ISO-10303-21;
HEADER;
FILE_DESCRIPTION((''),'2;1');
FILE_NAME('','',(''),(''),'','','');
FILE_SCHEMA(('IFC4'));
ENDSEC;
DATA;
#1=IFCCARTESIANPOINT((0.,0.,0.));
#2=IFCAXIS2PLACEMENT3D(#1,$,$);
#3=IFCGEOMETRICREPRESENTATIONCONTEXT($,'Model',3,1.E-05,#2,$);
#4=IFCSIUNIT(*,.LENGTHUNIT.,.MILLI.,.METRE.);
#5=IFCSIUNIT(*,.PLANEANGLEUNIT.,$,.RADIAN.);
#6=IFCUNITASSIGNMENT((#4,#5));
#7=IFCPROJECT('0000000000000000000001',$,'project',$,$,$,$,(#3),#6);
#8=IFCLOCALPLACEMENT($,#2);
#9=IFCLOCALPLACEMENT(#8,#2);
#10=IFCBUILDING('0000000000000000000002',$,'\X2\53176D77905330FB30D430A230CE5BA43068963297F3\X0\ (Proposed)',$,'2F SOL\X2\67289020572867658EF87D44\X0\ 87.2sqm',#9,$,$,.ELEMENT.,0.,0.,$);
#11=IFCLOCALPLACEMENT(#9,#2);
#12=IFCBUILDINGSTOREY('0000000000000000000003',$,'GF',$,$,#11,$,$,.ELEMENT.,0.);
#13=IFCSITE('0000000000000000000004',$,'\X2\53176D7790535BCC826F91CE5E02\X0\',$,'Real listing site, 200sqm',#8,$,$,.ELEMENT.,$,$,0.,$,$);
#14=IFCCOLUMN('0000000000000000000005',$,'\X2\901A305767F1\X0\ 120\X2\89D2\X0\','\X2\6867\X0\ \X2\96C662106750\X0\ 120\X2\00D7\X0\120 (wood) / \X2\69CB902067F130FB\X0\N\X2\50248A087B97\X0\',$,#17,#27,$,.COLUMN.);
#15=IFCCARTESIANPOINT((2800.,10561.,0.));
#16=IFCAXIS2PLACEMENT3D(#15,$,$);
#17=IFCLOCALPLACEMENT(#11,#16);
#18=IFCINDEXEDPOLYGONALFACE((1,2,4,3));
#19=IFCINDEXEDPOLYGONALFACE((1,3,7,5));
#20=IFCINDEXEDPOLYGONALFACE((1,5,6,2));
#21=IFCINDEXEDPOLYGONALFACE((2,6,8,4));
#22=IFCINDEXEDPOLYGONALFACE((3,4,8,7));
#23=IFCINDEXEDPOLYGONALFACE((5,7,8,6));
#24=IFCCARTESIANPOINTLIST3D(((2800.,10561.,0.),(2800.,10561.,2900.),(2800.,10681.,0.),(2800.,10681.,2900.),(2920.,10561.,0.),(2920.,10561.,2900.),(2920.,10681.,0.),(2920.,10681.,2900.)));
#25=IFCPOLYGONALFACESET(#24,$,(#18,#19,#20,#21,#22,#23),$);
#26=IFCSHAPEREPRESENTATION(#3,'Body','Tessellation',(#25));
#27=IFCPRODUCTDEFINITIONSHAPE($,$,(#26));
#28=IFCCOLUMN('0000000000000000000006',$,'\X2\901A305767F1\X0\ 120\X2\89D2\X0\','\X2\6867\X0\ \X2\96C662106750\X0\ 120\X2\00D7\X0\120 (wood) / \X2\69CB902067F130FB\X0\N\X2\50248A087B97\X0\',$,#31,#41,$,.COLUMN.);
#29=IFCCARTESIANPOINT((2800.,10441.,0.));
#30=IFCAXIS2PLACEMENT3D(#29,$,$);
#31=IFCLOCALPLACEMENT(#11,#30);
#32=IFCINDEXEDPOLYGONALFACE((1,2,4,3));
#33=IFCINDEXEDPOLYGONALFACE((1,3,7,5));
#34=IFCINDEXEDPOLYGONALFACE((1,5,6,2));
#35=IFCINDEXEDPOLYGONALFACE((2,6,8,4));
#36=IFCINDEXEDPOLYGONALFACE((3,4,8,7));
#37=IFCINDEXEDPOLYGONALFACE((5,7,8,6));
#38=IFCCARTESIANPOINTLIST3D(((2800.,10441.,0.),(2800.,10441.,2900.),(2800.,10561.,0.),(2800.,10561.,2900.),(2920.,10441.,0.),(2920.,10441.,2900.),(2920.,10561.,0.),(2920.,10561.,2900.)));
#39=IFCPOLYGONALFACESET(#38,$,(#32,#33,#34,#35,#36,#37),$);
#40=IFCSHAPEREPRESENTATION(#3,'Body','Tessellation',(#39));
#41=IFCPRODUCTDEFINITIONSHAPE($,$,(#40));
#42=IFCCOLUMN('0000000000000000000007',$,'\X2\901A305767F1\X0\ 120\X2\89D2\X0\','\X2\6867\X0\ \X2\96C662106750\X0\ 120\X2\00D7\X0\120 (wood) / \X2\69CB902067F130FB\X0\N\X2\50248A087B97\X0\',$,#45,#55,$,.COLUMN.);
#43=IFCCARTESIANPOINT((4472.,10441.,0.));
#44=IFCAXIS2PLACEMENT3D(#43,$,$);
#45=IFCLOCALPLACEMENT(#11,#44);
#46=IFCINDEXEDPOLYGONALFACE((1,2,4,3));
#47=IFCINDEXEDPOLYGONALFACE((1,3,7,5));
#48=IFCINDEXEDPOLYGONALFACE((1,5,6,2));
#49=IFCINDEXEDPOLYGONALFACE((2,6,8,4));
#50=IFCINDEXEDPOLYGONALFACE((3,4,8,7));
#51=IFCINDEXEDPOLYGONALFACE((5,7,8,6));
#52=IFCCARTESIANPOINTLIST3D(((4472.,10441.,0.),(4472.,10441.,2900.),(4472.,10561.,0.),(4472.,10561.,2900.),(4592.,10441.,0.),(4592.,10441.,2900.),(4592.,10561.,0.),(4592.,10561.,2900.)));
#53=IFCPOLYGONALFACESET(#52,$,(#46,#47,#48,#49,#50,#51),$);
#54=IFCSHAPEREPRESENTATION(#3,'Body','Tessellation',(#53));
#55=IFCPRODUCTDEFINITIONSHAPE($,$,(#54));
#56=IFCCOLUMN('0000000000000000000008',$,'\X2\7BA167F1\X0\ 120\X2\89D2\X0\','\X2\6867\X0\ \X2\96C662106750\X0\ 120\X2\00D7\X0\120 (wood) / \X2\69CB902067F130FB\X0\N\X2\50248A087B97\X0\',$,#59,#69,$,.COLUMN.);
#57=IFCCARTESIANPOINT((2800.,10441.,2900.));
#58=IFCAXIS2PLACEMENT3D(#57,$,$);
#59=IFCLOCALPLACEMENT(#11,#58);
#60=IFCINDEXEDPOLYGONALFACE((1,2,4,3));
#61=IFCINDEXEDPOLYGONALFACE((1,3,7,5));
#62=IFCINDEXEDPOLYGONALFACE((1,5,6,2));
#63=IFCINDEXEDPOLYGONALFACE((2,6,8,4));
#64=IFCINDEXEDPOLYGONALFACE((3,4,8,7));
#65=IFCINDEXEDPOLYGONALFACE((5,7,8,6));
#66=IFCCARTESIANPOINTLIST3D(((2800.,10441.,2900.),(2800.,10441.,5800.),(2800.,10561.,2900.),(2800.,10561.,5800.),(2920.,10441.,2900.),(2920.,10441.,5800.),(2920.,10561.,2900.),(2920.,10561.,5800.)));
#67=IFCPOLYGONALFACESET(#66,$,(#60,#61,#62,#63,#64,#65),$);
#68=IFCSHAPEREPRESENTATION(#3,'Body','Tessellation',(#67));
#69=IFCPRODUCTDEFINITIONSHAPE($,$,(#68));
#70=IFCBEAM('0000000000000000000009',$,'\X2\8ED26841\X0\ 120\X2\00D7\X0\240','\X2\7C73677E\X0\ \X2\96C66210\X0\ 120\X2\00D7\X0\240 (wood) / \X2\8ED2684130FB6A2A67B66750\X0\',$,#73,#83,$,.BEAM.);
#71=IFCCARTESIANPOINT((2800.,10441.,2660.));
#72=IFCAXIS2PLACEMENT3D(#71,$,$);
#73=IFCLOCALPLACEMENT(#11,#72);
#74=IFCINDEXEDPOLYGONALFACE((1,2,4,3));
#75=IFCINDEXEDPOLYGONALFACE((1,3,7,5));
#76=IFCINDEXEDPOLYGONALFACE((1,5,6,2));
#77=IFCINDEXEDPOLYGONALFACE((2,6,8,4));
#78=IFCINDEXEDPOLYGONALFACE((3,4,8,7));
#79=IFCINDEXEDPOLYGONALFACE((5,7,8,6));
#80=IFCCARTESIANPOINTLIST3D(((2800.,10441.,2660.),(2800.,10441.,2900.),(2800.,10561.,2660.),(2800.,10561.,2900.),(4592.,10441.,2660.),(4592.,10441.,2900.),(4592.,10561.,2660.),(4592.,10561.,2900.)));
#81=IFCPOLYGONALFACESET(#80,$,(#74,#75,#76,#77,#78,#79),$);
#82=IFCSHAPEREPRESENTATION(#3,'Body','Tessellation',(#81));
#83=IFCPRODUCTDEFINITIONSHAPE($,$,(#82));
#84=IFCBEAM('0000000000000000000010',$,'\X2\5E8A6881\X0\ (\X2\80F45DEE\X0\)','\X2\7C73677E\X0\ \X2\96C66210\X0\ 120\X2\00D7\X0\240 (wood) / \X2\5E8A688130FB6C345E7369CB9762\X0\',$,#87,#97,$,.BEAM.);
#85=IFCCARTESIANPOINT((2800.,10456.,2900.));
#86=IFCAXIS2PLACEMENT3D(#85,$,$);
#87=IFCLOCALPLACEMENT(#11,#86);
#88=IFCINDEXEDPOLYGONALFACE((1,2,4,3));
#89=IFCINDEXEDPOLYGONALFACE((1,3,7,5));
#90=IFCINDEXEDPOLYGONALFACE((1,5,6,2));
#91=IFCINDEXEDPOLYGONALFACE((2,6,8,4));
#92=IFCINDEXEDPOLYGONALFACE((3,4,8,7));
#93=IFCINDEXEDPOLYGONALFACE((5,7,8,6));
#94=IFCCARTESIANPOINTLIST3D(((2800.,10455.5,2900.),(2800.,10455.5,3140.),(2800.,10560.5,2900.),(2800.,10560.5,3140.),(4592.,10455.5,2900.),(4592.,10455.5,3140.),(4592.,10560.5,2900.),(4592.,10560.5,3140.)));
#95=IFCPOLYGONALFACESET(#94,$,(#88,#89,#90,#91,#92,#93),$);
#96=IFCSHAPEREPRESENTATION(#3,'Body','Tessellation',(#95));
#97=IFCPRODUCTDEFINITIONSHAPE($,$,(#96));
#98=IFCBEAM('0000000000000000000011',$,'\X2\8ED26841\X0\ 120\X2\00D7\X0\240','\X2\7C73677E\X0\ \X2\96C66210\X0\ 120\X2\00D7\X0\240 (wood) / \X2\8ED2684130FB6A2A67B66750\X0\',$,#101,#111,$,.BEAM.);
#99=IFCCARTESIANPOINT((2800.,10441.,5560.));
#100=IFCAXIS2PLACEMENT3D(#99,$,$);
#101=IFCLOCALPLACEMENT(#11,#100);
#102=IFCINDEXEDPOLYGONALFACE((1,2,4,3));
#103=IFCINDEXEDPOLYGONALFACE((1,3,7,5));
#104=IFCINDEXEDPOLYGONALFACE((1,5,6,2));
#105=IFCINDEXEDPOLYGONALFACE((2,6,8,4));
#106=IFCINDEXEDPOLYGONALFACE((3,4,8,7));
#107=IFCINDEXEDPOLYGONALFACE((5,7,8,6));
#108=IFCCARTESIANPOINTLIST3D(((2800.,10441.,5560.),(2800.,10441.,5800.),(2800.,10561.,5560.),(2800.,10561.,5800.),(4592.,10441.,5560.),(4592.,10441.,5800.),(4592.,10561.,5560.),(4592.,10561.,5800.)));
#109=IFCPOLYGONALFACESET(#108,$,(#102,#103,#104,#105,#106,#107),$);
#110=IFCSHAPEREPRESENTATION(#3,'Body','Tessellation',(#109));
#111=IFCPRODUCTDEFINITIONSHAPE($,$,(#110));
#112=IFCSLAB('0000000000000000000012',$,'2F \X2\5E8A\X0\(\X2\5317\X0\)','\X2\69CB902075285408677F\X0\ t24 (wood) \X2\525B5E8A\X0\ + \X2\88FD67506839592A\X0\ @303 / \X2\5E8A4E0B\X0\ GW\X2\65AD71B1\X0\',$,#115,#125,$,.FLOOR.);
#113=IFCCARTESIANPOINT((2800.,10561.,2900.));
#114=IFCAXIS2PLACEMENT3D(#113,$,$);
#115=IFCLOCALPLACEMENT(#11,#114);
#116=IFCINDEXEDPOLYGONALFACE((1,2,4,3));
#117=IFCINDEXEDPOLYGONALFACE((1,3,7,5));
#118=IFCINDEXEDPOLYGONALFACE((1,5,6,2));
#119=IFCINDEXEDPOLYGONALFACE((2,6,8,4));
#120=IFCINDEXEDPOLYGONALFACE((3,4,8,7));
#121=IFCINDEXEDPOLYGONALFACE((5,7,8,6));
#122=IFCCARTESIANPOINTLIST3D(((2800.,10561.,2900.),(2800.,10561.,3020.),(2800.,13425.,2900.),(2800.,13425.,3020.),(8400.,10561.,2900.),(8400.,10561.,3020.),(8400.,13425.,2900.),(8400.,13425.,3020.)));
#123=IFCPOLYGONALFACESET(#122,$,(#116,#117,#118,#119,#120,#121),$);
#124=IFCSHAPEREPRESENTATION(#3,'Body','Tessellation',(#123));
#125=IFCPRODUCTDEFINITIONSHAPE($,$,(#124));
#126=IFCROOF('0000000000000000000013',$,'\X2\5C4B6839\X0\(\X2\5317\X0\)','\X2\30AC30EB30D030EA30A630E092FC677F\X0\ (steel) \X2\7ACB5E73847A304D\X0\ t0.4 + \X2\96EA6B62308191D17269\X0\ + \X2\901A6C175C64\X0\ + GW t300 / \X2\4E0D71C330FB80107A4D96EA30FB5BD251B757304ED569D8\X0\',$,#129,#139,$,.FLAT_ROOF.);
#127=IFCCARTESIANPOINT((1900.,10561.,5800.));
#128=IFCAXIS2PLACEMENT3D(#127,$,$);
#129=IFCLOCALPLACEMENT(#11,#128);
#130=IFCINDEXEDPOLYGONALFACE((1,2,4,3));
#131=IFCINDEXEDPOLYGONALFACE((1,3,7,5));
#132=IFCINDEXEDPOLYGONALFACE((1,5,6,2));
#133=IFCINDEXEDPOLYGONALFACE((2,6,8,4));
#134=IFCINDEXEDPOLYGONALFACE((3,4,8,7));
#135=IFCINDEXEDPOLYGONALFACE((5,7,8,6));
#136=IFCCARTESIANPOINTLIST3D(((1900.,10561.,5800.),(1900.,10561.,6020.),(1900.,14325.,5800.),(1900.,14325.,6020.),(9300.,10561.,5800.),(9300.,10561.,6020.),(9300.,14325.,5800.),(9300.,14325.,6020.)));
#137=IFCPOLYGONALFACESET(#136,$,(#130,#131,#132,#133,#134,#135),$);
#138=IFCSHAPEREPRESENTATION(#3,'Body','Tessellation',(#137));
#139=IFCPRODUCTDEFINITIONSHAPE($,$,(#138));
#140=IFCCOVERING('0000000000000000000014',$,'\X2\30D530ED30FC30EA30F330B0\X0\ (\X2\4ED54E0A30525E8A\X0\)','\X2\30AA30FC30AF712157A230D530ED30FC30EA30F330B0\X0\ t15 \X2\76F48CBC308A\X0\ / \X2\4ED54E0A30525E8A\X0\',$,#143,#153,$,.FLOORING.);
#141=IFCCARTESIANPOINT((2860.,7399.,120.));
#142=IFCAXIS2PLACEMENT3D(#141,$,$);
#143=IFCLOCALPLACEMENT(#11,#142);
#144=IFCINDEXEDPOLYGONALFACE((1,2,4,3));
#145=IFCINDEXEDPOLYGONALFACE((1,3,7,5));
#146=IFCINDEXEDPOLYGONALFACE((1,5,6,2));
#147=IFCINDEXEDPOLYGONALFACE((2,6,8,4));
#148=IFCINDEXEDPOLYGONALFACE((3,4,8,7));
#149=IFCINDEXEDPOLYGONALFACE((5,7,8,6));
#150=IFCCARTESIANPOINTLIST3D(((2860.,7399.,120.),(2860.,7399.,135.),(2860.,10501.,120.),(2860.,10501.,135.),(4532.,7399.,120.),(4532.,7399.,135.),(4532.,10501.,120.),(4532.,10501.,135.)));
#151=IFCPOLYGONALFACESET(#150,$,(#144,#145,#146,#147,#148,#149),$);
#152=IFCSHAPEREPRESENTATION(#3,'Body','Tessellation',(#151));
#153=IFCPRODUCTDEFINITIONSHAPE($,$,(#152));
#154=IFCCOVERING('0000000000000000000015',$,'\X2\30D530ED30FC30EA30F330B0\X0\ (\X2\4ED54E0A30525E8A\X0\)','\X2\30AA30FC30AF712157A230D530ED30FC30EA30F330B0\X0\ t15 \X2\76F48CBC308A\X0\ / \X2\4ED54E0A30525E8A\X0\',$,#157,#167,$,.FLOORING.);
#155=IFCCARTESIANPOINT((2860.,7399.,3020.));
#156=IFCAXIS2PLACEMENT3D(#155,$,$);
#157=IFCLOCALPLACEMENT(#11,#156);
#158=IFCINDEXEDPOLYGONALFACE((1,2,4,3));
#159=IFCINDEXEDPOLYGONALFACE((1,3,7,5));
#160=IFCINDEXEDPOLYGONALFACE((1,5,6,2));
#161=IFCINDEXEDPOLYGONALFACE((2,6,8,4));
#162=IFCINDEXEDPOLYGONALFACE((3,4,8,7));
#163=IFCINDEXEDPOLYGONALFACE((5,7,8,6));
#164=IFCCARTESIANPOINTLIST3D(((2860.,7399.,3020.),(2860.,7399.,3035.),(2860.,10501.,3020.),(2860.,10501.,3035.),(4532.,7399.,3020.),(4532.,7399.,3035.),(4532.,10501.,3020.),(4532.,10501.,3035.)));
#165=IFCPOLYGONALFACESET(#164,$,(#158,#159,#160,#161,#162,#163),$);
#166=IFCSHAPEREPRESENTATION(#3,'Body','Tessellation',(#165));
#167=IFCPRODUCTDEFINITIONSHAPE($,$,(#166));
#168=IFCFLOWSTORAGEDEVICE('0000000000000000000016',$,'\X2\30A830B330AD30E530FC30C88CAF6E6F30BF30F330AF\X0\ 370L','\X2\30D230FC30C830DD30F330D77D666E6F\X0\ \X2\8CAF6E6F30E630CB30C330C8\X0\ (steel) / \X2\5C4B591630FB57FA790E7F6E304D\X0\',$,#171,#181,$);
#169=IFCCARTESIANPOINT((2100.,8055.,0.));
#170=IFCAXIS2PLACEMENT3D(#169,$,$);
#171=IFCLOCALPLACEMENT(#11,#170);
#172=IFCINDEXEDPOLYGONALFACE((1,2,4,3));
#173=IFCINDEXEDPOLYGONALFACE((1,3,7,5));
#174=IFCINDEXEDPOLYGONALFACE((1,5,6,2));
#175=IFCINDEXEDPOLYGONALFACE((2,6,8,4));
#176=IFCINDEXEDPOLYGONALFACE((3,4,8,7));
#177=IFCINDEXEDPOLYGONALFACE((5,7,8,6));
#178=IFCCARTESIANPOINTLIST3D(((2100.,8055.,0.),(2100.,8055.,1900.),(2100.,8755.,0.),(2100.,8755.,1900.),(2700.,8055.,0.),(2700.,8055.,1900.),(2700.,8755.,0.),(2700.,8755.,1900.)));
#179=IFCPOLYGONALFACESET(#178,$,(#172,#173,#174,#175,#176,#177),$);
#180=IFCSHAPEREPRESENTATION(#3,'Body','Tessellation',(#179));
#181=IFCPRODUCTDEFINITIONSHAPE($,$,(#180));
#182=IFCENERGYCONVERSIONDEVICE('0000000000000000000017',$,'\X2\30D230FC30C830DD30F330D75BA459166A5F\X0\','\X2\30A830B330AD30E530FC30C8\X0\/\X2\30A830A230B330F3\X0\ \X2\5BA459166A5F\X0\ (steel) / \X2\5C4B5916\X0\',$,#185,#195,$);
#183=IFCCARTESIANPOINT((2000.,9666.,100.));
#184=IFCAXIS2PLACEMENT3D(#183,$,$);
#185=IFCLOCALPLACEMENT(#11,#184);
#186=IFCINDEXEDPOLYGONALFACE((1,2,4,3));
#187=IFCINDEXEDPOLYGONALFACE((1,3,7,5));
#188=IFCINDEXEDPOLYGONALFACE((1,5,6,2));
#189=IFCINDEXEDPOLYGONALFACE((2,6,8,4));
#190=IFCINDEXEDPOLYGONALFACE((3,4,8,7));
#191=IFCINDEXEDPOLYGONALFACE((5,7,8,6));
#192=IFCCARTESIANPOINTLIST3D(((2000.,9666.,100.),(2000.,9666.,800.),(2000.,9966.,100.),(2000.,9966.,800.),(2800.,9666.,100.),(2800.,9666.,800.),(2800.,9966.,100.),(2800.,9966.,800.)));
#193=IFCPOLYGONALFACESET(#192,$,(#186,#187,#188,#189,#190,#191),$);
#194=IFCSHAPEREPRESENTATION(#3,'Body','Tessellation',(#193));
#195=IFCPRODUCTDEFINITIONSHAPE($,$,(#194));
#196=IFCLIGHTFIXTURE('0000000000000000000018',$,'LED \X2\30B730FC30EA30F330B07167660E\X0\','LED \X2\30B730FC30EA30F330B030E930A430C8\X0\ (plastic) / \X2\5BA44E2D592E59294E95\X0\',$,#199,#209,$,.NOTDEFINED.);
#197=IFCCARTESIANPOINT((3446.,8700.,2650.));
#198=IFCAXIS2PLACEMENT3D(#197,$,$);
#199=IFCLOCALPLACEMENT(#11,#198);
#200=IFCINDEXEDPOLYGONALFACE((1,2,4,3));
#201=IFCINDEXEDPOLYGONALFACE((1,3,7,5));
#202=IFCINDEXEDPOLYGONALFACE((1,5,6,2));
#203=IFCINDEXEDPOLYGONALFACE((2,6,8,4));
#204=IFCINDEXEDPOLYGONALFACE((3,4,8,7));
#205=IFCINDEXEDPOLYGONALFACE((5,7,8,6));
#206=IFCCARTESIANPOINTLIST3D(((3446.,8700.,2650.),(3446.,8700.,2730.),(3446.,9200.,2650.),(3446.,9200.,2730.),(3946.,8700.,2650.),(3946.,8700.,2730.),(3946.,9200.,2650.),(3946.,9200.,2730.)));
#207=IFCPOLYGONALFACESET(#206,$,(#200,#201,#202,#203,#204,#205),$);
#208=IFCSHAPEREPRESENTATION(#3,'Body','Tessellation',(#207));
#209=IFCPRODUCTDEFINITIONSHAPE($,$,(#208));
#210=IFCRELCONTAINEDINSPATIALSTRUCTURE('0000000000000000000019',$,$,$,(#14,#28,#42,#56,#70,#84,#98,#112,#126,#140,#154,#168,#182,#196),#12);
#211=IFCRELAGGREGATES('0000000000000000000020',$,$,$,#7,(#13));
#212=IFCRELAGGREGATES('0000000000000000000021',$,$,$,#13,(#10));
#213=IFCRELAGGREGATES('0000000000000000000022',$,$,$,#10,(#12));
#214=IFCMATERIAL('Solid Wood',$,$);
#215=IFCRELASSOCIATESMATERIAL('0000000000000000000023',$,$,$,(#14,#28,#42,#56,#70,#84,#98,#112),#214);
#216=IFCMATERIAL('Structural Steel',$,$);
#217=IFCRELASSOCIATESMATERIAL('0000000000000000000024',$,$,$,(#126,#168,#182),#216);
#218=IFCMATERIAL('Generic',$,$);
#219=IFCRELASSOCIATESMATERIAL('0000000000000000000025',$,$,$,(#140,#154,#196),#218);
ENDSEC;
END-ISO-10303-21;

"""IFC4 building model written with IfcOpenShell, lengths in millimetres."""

from ifc_helpers import new_model, si_unit, frame, frame_2d, origin, place, context, project, spatial, rectangle, extrude, material, element, save


model = new_model("IFC4")

# Units and contexts
model_context = context("Model", 3, precision=1e-05, world=origin())
ifc_project = project(units=[si_unit("LENGTHUNIT", "METRE", prefix="MILLI"), si_unit("PLANEANGLEUNIT", "RADIAN")], contexts=[model_context])

# Site, building, storey
site_placement = place(None, origin())
site = spatial("IfcSite", under=ifc_project, at=site_placement, Name="北海道富良野市", ObjectType="Real listing site, 200sqm", CompositionType="ELEMENT", RefElevation=0.0)
building_placement = place(site_placement, origin())
building = spatial("IfcBuilding", under=site, at=building_placement, Name="北海道・ピアノ室と防音 (Proposed)", ObjectType="2F SOL木造在来軸組 87.2sqm", CompositionType="ELEMENT", ElevationOfRefHeight=0.0, ElevationOfTerrain=0.0)
storey_placement = place(building_placement, origin())
storey = spatial("IfcBuildingStorey", under=building, at=storey_placement, Name="GF", CompositionType="ELEMENT", Elevation=0.0)

# Columns
ifc_material_1 = material(Name="Solid Wood")
column_1_placement = place(storey_placement, frame((2800.0, 10561.0, 0.0)))
element("IfcColumn", 1, at=column_1_placement, inside=storey, material=ifc_material_1, Name="通し柱 120角", Description="桧 集成材 120×120 (wood) / 構造柱・N値計算", PredefinedType="COLUMN", context=model_context, shape_type="SweptSolid", body=[
    extrude(rectangle(XDim=120.0, YDim=120.0, at=frame_2d((60.0, 60.0))), frame((2800.0, 10561.0, 0.0)), (0.0, 0.0, 1.0), 2900.0),
])
column_2_placement = place(storey_placement, frame((2800.0, 10441.0, 0.0)))
element("IfcColumn", 2, at=column_2_placement, inside=storey, material=ifc_material_1, Name="通し柱 120角", Description="桧 集成材 120×120 (wood) / 構造柱・N値計算", PredefinedType="COLUMN", context=model_context, shape_type="SweptSolid", body=[
    extrude(rectangle(XDim=120.0, YDim=120.0, at=frame_2d((60.0, 60.0))), frame((2800.0, 10441.0, 0.0)), (0.0, 0.0, 1.0), 2900.0),
])
column_3_placement = place(storey_placement, frame((4472.0, 10441.0, 0.0)))
element("IfcColumn", 3, at=column_3_placement, inside=storey, material=ifc_material_1, Name="通し柱 120角", Description="桧 集成材 120×120 (wood) / 構造柱・N値計算", PredefinedType="COLUMN", context=model_context, shape_type="SweptSolid", body=[
    extrude(rectangle(XDim=120.0, YDim=120.0, at=frame_2d((60.0, 60.0))), frame((4472.0, 10441.0, 0.0)), (0.0, 0.0, 1.0), 2900.0),
])
column_4_placement = place(storey_placement, frame((2800.0, 10441.0, 2900.0)))
element("IfcColumn", 4, at=column_4_placement, inside=storey, material=ifc_material_1, Name="管柱 120角", Description="桧 集成材 120×120 (wood) / 構造柱・N値計算", PredefinedType="COLUMN", context=model_context, shape_type="SweptSolid", body=[
    extrude(rectangle(XDim=120.0, YDim=120.0, at=frame_2d((60.0, 60.0))), frame((2800.0, 10441.0, 2900.0)), (0.0, 0.0, 1.0), 2900.0),
])

# Beams
beam_1_placement = place(storey_placement, frame((2800.0, 10441.0, 2660.0)))
element("IfcBeam", 5, at=beam_1_placement, inside=storey, material=ifc_material_1, Name="軒桁 120×240", Description="米松 集成 120×240 (wood) / 軒桁・横架材", PredefinedType="BEAM", context=model_context, shape_type="SweptSolid", body=[
    extrude(rectangle(XDim=1792.0, YDim=120.0, at=frame_2d((896.0, 60.0))), frame((2800.0, 10441.0, 2660.0)), (0.0, 0.0, 1.0), 240.0),
])
beam_2_placement = place(storey_placement, frame((2800.0, 10456.0, 2900.0)))
element("IfcBeam", 6, at=beam_2_placement, inside=storey, material=ifc_material_1, Name="床梁 (胴差)", Description="米松 集成 120×240 (wood) / 床梁・水平構面", PredefinedType="BEAM", context=model_context, shape_type="SweptSolid", body=[
    extrude(rectangle(XDim=1792.0, YDim=105.0, at=frame_2d((896.0, 52.0))), frame((2800.0, 10456.0, 2900.0)), (0.0, 0.0, 1.0), 240.0),
])
beam_3_placement = place(storey_placement, frame((2800.0, 10441.0, 5560.0)))
element("IfcBeam", 7, at=beam_3_placement, inside=storey, material=ifc_material_1, Name="軒桁 120×240", Description="米松 集成 120×240 (wood) / 軒桁・横架材", PredefinedType="BEAM", context=model_context, shape_type="SweptSolid", body=[
    extrude(rectangle(XDim=1792.0, YDim=120.0, at=frame_2d((896.0, 60.0))), frame((2800.0, 10441.0, 5560.0)), (0.0, 0.0, 1.0), 240.0),
])

# Slab
slab_1_placement = place(storey_placement, frame((2800.0, 10561.0, 2900.0)))
element("IfcSlab", 8, at=slab_1_placement, inside=storey, material=ifc_material_1, Name="2F 床(北)", Description="構造用合板 t24 (wood) 剛床 + 製材根太 @303 / 床下 GW断熱", PredefinedType="FLOOR", context=model_context, shape_type="SweptSolid", body=[
    extrude(rectangle(XDim=5600.0, YDim=2864.0, at=frame_2d((2800.0, 1432.0))), frame((2800.0, 10561.0, 2900.0)), (0.0, 0.0, 1.0), 120.0),
])

# Roof
ifc_material_2 = material(Name="Structural Steel")
for number, where, name in (
    (9, (1900.0, 10561.0, 5800.0), "屋根(北)"),
):
    element("IfcRoof", number, at=place(storey_placement, frame(where)), inside=storey, material=ifc_material_2, Name=name, Description="ガルバリウム鋼板 (steel) 立平葺き t0.4 + 雪止め金物 + 通気層 + GW t300 / 不燃・耐積雪・寒冷地仕様", PredefinedType="FLAT_ROOF", context=model_context, shape_type="SweptSolid", body=[
        extrude(rectangle(XDim=7400.0, YDim=3764.0, at=frame_2d((3700.0, 1882.0))), frame((1900.0, 10561.0, 5800.0)), (0.0, 0.0, 1.0), 220.0),
    ])

# Coverings
ifc_material_3 = material(Name="Generic")
covering_1_placement = place(storey_placement, frame((2860.0, 7399.0, 120.0)))
element("IfcCovering", 10, at=covering_1_placement, inside=storey, material=ifc_material_3, Name="フローリング (仕上げ床)", Description="オーク無垢フローリング t15 直貼り / 仕上げ床", PredefinedType="FLOORING", context=model_context, shape_type="SweptSolid", body=[
    extrude(rectangle(XDim=1672.0, YDim=3102.0, at=frame_2d((836.0, 1551.0))), frame((2860.0, 7399.0, 120.0)), (0.0, 0.0, 1.0), 15.0),
])
covering_2_placement = place(storey_placement, frame((2860.0, 7399.0, 3020.0)))
element("IfcCovering", 11, at=covering_2_placement, inside=storey, material=ifc_material_3, Name="フローリング (仕上げ床)", Description="オーク無垢フローリング t15 直貼り / 仕上げ床", PredefinedType="FLOORING", context=model_context, shape_type="SweptSolid", body=[
    extrude(rectangle(XDim=1672.0, YDim=3102.0, at=frame_2d((836.0, 1551.0))), frame((2860.0, 7399.0, 3020.0)), (0.0, 0.0, 1.0), 15.0),
])

# Flow storage device
flow_storage_device_placement = place(storey_placement, frame((2100.0, 8055.0, 0.0)))
element("IfcFlowStorageDevice", 12, at=flow_storage_device_placement, inside=storey, material=ifc_material_2, Name="エコキュート貯湯タンク 370L", Description="ヒートポンプ給湯 貯湯ユニット (steel) / 屋外・基礎置き", context=model_context, shape_type="SweptSolid", body=[
    extrude(rectangle(XDim=600.0, YDim=700.0, at=frame_2d((300.0, 350.0))), frame((2100.0, 8055.0, 0.0)), (0.0, 0.0, 1.0), 1900.0),
])

# Energy conversion device
energy_conversion_device_placement = place(storey_placement, frame((2000.0, 9666.0, 100.0)))
element("IfcEnergyConversionDevice", 13, at=energy_conversion_device_placement, inside=storey, material=ifc_material_2, Name="ヒートポンプ室外機", Description="エコキュート/エアコン 室外機 (steel) / 屋外", context=model_context, shape_type="SweptSolid", body=[
    extrude(rectangle(XDim=800.0, YDim=300.0, at=frame_2d((400.0, 150.0))), frame((2000.0, 9666.0, 100.0)), (0.0, 0.0, 1.0), 700.0),
])

# Light fixture
light_fixture_1_placement = place(storey_placement, frame((3446.0, 8700.0, 2650.0)))
element("IfcLightFixture", 14, at=light_fixture_1_placement, inside=storey, material=ifc_material_3, Name="LED シーリング照明", Description="LED シーリングライト (plastic) / 室中央天井", PredefinedType="NOTDEFINED", context=model_context, shape_type="SweptSolid", body=[
    extrude(rectangle(XDim=500.0, YDim=500.0, at=frame_2d((250.0, 250.0))), frame((3446.0, 8700.0, 2650.0)), (0.0, 0.0, 1.0), 80.0),
])

save(model, "model.ifc")
